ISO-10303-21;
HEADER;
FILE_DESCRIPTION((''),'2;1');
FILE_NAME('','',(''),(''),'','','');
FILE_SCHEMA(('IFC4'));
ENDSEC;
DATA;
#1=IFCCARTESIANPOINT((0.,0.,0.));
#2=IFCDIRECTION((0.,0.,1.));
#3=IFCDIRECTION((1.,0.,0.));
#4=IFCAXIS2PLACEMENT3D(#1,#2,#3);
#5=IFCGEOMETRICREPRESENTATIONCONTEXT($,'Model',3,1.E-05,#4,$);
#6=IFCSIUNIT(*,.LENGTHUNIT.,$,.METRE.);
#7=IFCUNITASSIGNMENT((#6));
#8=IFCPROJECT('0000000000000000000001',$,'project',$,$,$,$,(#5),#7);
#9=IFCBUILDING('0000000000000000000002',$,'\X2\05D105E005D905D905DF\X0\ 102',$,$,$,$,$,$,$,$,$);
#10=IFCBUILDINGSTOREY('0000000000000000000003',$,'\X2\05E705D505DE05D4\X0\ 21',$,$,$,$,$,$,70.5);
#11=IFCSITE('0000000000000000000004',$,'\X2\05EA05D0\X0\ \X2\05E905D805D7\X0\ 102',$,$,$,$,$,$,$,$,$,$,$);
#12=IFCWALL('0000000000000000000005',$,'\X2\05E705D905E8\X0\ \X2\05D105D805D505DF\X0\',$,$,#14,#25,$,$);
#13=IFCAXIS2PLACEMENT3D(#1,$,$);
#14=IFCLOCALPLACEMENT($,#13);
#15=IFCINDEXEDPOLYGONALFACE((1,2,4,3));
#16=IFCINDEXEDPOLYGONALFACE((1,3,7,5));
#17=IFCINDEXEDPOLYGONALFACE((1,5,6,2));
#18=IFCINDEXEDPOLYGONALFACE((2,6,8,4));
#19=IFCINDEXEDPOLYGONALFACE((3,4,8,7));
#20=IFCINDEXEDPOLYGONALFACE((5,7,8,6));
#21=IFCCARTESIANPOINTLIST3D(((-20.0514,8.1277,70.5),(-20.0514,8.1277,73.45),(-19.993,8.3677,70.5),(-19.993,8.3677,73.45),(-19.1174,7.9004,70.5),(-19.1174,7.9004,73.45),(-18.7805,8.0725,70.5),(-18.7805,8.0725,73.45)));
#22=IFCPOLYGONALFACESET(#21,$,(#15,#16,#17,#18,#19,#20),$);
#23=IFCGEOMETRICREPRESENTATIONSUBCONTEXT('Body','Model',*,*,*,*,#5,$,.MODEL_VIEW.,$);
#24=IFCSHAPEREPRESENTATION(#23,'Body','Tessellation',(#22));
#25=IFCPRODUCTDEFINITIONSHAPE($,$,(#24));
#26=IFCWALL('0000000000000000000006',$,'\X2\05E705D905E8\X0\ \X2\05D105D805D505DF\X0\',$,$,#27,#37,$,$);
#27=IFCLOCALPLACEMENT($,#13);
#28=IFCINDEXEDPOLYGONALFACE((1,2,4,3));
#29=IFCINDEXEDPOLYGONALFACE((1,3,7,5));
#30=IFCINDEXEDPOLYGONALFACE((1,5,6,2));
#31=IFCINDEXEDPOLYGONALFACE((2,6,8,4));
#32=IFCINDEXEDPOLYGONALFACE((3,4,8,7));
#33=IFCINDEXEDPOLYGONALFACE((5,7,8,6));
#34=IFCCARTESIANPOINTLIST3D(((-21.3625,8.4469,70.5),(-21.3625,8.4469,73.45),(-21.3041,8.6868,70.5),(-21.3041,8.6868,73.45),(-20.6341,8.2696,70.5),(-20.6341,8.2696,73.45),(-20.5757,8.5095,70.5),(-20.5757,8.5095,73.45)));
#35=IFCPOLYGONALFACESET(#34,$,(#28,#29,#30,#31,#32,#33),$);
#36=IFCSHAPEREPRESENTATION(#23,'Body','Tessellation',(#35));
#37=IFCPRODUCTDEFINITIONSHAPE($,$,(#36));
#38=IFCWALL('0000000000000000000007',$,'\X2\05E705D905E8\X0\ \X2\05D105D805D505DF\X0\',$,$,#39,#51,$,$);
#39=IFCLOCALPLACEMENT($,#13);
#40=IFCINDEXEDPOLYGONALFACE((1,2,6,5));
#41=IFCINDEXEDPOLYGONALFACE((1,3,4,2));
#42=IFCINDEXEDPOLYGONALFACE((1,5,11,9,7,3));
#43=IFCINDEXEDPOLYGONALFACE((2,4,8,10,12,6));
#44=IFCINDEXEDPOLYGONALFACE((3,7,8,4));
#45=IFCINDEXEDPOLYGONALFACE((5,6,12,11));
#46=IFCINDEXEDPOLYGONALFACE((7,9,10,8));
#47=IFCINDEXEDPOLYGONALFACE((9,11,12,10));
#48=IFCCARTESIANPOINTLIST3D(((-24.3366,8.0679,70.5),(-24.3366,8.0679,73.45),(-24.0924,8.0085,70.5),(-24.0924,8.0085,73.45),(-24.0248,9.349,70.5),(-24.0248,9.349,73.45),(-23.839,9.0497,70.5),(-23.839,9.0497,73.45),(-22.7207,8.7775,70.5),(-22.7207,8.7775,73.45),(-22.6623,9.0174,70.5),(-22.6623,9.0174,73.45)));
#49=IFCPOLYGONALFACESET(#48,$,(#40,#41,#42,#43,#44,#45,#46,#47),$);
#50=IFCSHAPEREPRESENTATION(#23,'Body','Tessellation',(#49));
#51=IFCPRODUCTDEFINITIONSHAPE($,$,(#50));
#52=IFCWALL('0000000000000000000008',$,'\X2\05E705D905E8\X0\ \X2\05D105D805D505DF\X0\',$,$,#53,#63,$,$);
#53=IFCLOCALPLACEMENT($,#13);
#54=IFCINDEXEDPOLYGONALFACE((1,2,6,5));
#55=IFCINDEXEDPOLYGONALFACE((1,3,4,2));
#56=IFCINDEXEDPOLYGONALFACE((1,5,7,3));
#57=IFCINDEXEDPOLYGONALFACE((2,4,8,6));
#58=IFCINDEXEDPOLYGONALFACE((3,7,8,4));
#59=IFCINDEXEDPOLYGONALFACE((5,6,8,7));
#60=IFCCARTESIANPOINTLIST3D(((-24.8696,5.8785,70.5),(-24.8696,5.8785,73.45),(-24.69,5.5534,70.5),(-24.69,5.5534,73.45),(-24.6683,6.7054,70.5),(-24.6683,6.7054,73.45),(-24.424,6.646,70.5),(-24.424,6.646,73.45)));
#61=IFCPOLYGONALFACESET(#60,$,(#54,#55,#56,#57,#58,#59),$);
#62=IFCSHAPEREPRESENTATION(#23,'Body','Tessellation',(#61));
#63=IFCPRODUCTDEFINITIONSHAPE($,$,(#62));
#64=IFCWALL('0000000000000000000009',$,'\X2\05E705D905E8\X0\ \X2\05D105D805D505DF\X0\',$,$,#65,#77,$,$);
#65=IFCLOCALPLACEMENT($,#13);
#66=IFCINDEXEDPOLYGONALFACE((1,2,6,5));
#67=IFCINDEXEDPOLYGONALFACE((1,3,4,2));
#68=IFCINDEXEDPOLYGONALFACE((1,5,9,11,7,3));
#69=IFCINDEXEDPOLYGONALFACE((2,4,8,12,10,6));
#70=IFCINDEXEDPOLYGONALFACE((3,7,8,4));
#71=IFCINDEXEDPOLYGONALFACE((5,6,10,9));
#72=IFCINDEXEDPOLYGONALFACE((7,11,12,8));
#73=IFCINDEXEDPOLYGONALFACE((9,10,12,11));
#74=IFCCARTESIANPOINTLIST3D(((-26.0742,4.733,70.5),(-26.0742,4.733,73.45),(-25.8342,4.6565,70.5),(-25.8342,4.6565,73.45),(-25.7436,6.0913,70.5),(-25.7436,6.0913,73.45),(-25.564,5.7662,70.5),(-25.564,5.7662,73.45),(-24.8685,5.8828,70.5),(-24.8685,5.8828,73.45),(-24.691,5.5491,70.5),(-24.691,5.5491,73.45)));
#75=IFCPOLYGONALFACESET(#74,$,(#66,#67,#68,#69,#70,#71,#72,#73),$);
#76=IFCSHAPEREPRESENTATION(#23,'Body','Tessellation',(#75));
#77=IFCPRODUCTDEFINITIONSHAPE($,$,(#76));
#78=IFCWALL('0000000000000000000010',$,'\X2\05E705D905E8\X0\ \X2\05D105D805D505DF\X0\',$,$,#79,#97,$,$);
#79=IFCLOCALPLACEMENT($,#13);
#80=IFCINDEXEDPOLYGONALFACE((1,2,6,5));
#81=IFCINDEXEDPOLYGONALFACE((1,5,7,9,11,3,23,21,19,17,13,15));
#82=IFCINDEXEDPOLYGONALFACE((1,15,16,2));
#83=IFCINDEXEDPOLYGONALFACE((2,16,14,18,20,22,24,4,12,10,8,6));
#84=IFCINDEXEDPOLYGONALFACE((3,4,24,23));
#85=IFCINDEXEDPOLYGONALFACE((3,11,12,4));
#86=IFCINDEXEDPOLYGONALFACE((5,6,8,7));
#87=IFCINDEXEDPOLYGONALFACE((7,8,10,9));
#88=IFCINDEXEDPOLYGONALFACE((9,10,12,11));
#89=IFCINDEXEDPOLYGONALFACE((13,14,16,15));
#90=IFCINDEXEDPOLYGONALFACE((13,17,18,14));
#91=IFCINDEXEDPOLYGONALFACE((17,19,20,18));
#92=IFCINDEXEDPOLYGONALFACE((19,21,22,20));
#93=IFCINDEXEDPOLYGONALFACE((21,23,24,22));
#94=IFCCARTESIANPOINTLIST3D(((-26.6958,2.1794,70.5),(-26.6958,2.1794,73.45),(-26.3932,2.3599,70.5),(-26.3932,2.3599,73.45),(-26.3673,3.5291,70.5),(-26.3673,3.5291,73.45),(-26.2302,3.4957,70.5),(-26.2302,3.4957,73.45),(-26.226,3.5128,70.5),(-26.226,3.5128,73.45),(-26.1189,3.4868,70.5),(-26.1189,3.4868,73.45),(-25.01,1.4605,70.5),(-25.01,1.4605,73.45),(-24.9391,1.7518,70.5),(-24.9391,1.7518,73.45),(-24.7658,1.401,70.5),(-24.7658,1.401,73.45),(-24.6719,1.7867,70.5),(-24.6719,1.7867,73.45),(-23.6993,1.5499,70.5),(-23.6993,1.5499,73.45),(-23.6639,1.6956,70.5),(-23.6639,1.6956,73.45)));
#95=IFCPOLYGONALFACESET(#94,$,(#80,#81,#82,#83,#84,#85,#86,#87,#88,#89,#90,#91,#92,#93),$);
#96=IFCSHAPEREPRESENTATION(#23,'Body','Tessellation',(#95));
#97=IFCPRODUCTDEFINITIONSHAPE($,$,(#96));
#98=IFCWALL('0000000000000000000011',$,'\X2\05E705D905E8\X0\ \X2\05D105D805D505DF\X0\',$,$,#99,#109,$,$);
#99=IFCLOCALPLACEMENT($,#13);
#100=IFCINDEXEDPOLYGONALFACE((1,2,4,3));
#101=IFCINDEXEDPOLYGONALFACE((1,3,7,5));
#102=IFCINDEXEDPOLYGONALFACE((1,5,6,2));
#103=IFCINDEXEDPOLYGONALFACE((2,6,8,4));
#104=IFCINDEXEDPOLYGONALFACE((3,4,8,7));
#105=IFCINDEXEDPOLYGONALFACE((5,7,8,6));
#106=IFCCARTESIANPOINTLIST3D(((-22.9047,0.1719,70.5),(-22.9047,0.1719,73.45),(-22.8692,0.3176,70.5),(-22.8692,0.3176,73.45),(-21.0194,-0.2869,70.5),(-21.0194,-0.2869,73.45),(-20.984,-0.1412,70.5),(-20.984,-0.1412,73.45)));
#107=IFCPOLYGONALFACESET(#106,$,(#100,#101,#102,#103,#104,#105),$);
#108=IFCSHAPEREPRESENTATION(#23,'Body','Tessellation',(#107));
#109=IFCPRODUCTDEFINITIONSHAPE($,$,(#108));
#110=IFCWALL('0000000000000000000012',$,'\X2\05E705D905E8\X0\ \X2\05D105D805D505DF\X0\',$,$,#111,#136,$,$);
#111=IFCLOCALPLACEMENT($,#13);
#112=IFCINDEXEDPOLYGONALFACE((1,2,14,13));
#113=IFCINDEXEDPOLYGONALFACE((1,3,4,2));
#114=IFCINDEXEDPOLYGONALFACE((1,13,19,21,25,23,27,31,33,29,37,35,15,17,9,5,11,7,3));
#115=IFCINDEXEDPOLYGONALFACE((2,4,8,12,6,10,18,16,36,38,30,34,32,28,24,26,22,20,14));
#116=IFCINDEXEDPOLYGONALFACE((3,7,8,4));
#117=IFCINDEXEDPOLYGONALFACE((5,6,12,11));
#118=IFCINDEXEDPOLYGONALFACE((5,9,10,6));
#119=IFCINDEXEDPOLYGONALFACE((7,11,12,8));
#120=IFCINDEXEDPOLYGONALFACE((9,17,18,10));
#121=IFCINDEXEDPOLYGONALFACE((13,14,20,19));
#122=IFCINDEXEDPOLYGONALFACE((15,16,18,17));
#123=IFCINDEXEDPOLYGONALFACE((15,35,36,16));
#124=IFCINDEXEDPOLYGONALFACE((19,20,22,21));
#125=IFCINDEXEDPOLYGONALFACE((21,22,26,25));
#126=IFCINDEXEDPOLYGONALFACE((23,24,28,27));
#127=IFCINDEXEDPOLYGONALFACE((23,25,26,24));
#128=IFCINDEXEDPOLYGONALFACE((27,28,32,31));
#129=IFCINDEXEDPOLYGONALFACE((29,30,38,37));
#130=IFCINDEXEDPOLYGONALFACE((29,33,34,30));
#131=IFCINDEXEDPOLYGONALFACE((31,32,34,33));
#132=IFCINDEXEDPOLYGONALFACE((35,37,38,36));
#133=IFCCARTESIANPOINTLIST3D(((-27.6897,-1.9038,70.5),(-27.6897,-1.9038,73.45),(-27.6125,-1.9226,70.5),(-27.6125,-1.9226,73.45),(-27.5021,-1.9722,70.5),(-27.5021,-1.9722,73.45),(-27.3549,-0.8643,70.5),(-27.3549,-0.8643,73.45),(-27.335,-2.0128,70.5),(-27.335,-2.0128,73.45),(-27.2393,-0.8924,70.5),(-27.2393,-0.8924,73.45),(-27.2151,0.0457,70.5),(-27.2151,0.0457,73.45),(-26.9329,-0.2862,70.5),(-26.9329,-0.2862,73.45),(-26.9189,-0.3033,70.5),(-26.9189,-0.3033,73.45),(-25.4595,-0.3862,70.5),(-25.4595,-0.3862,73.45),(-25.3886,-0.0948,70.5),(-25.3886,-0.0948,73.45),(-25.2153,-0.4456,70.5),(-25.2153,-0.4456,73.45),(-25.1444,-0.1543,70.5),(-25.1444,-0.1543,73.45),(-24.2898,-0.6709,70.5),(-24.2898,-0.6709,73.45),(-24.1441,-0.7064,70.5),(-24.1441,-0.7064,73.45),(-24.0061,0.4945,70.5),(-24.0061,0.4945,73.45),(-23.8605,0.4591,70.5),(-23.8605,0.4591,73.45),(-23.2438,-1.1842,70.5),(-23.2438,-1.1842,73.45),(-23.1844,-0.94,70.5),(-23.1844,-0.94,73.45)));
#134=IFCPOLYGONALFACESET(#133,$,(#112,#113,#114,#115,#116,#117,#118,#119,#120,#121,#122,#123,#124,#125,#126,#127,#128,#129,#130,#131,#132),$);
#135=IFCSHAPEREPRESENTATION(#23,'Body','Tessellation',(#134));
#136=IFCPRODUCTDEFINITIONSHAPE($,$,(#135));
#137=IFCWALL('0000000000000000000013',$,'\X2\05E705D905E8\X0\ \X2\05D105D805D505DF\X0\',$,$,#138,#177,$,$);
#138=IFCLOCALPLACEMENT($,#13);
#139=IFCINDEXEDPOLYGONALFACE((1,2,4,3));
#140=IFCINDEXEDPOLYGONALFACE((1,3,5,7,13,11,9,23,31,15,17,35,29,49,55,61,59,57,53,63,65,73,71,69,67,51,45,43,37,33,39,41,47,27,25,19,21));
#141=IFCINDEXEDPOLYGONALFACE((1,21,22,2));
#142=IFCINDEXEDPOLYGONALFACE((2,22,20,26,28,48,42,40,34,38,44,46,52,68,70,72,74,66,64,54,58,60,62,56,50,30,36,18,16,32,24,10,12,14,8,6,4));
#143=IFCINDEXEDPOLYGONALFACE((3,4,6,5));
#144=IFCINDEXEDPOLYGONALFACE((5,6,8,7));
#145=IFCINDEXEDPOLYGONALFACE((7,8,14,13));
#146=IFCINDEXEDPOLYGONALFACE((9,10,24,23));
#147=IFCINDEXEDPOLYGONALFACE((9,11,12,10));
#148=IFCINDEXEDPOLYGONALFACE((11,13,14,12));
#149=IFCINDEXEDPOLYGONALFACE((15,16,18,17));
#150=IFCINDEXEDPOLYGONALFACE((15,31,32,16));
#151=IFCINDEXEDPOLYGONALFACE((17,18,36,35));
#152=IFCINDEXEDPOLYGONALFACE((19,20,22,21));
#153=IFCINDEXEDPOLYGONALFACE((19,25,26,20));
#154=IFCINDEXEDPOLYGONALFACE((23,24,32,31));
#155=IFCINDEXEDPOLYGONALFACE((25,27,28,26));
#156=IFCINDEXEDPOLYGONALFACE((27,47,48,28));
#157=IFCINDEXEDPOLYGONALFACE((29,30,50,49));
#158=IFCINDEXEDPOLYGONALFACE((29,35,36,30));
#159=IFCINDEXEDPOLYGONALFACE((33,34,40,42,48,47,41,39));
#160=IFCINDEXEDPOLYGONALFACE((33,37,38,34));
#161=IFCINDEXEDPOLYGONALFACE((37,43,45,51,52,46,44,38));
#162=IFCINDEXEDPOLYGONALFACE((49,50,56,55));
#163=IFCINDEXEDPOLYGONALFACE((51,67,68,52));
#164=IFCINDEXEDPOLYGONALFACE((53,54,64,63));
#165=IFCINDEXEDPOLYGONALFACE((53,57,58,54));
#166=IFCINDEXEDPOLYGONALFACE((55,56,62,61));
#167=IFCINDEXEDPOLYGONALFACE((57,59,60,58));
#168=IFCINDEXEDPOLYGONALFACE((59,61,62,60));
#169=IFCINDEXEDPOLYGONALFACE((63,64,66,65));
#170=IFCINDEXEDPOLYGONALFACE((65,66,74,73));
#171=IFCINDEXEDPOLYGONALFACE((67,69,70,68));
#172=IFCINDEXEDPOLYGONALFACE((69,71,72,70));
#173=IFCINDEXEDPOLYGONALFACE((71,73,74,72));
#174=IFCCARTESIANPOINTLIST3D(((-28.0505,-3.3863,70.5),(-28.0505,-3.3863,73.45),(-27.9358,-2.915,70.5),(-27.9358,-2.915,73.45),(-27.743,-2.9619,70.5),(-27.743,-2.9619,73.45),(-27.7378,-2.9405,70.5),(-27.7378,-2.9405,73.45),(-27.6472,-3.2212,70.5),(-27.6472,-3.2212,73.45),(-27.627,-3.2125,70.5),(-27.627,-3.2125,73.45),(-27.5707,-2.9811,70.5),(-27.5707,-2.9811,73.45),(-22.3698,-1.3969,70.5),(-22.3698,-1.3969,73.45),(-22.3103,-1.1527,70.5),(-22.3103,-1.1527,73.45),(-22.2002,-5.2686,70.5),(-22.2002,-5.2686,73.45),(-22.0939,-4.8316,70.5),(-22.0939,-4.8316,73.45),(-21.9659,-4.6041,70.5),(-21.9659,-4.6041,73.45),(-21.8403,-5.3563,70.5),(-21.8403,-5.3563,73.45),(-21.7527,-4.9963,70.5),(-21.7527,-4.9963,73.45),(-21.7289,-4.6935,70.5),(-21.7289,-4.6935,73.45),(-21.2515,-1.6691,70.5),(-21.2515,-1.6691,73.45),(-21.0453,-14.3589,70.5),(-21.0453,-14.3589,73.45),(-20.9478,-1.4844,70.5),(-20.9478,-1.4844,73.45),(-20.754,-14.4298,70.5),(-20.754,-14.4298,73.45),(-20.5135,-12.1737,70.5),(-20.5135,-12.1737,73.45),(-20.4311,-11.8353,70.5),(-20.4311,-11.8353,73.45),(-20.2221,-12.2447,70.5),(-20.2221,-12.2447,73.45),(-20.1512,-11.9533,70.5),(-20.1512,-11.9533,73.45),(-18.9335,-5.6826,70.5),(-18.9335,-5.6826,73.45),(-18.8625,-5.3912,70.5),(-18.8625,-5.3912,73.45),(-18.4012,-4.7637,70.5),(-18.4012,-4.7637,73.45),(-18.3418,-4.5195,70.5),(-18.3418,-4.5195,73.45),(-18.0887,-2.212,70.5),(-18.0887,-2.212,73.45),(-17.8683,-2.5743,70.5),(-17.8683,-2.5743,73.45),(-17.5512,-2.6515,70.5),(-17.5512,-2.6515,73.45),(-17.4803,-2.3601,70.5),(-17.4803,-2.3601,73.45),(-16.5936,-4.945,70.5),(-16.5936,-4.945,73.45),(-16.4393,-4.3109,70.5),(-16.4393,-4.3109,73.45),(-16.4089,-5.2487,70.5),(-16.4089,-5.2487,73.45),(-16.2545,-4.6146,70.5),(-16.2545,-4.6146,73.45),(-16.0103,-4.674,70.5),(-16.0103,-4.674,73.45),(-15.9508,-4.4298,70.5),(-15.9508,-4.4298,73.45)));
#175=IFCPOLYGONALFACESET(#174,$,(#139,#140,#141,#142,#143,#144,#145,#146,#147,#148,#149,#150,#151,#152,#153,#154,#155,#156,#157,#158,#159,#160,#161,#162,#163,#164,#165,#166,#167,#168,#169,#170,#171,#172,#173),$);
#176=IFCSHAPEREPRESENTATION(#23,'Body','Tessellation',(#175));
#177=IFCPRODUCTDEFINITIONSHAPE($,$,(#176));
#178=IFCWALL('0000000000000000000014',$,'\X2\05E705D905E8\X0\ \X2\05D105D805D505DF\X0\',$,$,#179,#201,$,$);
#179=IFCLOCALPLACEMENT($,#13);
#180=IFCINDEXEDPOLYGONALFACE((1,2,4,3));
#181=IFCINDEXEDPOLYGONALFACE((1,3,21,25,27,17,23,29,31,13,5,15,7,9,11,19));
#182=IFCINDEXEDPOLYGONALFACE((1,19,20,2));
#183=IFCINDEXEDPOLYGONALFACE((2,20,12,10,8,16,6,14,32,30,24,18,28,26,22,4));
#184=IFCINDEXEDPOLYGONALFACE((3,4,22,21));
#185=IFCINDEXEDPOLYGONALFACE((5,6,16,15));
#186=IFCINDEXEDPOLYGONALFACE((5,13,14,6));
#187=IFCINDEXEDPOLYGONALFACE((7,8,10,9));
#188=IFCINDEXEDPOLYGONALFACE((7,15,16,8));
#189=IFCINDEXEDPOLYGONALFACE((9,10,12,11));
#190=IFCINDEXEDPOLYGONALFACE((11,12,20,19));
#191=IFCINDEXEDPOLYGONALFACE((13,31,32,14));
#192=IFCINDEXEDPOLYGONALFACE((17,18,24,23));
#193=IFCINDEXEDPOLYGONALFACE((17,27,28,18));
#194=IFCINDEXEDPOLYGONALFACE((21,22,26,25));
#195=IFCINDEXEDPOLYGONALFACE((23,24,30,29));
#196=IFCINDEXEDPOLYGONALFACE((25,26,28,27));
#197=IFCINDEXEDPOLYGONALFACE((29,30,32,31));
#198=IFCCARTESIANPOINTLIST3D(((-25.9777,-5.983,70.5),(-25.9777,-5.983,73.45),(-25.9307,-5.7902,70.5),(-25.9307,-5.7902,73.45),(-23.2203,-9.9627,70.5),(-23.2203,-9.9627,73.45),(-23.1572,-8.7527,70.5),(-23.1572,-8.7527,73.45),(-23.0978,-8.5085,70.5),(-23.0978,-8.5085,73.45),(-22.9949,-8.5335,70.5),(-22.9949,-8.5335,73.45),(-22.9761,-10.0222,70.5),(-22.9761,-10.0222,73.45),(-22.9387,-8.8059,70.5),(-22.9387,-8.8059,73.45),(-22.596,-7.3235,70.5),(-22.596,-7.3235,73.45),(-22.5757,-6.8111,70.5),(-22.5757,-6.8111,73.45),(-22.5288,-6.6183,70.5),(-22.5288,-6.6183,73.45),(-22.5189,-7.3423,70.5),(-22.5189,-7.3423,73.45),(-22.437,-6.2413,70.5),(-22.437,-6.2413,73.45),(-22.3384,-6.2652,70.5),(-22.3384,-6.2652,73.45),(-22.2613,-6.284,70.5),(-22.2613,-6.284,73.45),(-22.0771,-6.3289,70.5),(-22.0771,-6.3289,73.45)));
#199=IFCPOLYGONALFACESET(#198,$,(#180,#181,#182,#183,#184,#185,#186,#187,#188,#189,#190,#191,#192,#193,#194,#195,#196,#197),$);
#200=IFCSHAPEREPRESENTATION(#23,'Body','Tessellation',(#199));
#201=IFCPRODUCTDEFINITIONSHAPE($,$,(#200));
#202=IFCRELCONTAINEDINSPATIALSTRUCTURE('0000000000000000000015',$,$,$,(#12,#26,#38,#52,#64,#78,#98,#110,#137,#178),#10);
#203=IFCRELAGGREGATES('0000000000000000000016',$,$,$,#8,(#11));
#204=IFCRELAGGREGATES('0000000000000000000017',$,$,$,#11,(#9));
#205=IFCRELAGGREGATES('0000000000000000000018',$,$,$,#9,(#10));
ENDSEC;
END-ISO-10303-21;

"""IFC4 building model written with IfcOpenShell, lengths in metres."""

from ifc_helpers import new_model, si_unit, frame, origin_with_axes, context, subcontext, project, spatial, polyline, outline, extrude, element, save


model = new_model("IFC4")

# Units and contexts
model_context = context("Model", 3, precision=1e-05, world=origin_with_axes())
body_context = subcontext(model_context, "Body", "Model", "MODEL_VIEW")
ifc_project = project(units=[si_unit("LENGTHUNIT", "METRE")], contexts=[model_context])

# Site, building, storey
site = spatial("IfcSite", under=ifc_project, Name="תא שטח 102")
building = spatial("IfcBuilding", under=site, Name="בניין 102")
storey = spatial("IfcBuildingStorey", under=building, Name="קומה 21", Elevation=70.5)

# Walls
element("IfcWall", 1, inside=storey, Name="קיר בטון", context=body_context, shape_type="SweptSolid", body=[
    extrude(outline(polyline([(-19.1174, 7.9004), (-18.7805, 8.0725), (-19.993, 8.3677), (-20.0514, 8.1277), (-19.1174, 7.9004)])), frame((0.0, 0.0, 70.5)), (0.0, 0.0, 1.0), 2.95),
])
element("IfcWall", 2, inside=storey, Name="קיר בטון", context=body_context, shape_type="SweptSolid", body=[
    extrude(outline(polyline([(-20.5757, 8.5095), (-21.3041, 8.6868), (-21.3625, 8.4469), (-20.6341, 8.2696), (-20.5757, 8.5095)])), frame((0.0, 0.0, 70.5)), (0.0, 0.0, 1.0), 2.95),
])
element("IfcWall", 3, inside=storey, Name="קיר בטון", context=body_context, shape_type="SweptSolid", body=[
    extrude(outline(polyline([(-22.7207, 8.7775), (-22.6623, 9.0174), (-24.0248, 9.349), (-24.3366, 8.0679), (-24.0924, 8.0085), (-23.839, 9.0497), (-22.7207, 8.7775)])), frame((0.0, 0.0, 70.5)), (0.0, 0.0, 1.0), 2.95),
])
element("IfcWall", 4, inside=storey, Name="קיר בטון", context=body_context, shape_type="SweptSolid", body=[
    extrude(outline(polyline([(-24.8696, 5.8785), (-24.69, 5.5534), (-24.424, 6.646), (-24.6683, 6.7054), (-24.8696, 5.8785)])), frame((0.0, 0.0, 70.5)), (0.0, 0.0, 1.0), 2.95),
])
element("IfcWall", 5, inside=storey, Name="קיר בטון", context=body_context, shape_type="SweptSolid", body=[
    extrude(outline(polyline([(-26.0742, 4.733), (-25.8342, 4.6565), (-25.564, 5.7662), (-24.691, 5.5491), (-24.8685, 5.8828), (-25.7436, 6.0913), (-26.0742, 4.733)])), frame((0.0, 0.0, 70.5)), (0.0, 0.0, 1.0), 2.95),
])
element("IfcWall", 6, inside=storey, Name="קיר בטון", context=body_context, shape_type="SweptSolid", body=[
    extrude(outline(polyline([(-26.6958, 2.1794), (-24.9391, 1.7518), (-25.01, 1.4605), (-24.7658, 1.401), (-24.6719, 1.7867), (-23.6993, 1.5499), (-23.6639, 1.6956), (-26.3932, 2.3599), (-26.1189, 3.4868), (-26.226, 3.5128), (-26.2302, 3.4957), (-26.3673, 3.5291), (-26.6958, 2.1794)])), frame((0.0, 0.0, 70.5)), (0.0, 0.0, 1.0), 2.95),
])
element("IfcWall", 7, inside=storey, Name="קיר בטון", context=body_context, shape_type="SweptSolid", body=[
    extrude(outline(polyline([(-22.9047, 0.1719), (-21.0194, -0.2869), (-20.984, -0.1412), (-22.8692, 0.3176), (-22.9047, 0.1719)])), frame((0.0, 0.0, 70.5)), (0.0, 0.0, 1.0), 2.95),
])
element("IfcWall", 8, inside=storey, Name="קיר בטון", context=body_context, shape_type="SweptSolid", body=[
    extrude(outline(polyline([(-25.4595, -0.3862), (-27.2151, 0.0457), (-27.6897, -1.9038), (-27.6125, -1.9226), (-27.3549, -0.8643), (-27.2393, -0.8924), (-27.5021, -1.9722), (-27.335, -2.0128), (-26.9189, -0.3033), (-26.9329, -0.2862), (-23.2438, -1.1842), (-23.1844, -0.94), (-24.1441, -0.7064), (-23.8605, 0.4591), (-24.0061, 0.4945), (-24.2898, -0.6709), (-25.2153, -0.4456), (-25.1444, -0.1543), (-25.3886, -0.0948), (-25.4595, -0.3862)])), frame((0.0, 0.0, 70.5)), (0.0, 0.0, 1.0), 2.95),
])
element("IfcWall", 9, inside=storey, Name="קיר בטון", context=body_context, shape_type="SweptSolid", body=[
    extrude(outline(polyline([(-21.9659, -4.6041), (-27.6472, -3.2212), (-27.627, -3.2125), (-27.5707, -2.9811), (-27.7378, -2.9405), (-27.743, -2.9619), (-27.9358, -2.915), (-28.0505, -3.3863), (-22.0939, -4.8316), (-22.2002, -5.2686), (-21.8403, -5.3563), (-21.7527, -4.9963), (-18.9335, -5.6826), (-20.4311, -11.8353), (-20.5135, -12.1737), (-21.0453, -14.3589), (-20.754, -14.4298), (-20.2221, -12.2447), (-20.1512, -11.9533), (-18.4012, -4.7637), (-16.4089, -5.2487), (-16.2545, -4.6146), (-16.0103, -4.674), (-15.9508, -4.4298), (-16.4393, -4.3109), (-16.5936, -4.945), (-18.3418, -4.5195), (-17.8683, -2.5743), (-17.5512, -2.6515), (-17.4803, -2.3601), (-18.0887, -2.212), (-18.8625, -5.3912), (-21.7289, -4.6935), (-20.9478, -1.4844), (-22.3103, -1.1527), (-22.3698, -1.3969), (-21.2515, -1.6691), (-21.9659, -4.6041)])), frame((0.0, 0.0, 70.5)), (0.0, 0.0, 1.0), 2.95),
])
element("IfcWall", 10, inside=storey, Name="קיר בטון", context=body_context, shape_type="SweptSolid", body=[
    extrude(outline(polyline([(-25.9777, -5.983), (-22.5757, -6.8111), (-22.9949, -8.5335), (-23.0978, -8.5085), (-23.1572, -8.7527), (-22.9387, -8.8059), (-23.2203, -9.9627), (-22.9761, -10.0222), (-22.0771, -6.3289), (-22.2613, -6.284), (-22.5189, -7.3423), (-22.596, -7.3235), (-22.3384, -6.2652), (-22.437, -6.2413), (-22.5288, -6.6183), (-25.9307, -5.7902), (-25.9777, -5.983)])), frame((0.0, 0.0, 70.5)), (0.0, 0.0, 1.0), 2.95),
])

save(model, "model.ifc")
